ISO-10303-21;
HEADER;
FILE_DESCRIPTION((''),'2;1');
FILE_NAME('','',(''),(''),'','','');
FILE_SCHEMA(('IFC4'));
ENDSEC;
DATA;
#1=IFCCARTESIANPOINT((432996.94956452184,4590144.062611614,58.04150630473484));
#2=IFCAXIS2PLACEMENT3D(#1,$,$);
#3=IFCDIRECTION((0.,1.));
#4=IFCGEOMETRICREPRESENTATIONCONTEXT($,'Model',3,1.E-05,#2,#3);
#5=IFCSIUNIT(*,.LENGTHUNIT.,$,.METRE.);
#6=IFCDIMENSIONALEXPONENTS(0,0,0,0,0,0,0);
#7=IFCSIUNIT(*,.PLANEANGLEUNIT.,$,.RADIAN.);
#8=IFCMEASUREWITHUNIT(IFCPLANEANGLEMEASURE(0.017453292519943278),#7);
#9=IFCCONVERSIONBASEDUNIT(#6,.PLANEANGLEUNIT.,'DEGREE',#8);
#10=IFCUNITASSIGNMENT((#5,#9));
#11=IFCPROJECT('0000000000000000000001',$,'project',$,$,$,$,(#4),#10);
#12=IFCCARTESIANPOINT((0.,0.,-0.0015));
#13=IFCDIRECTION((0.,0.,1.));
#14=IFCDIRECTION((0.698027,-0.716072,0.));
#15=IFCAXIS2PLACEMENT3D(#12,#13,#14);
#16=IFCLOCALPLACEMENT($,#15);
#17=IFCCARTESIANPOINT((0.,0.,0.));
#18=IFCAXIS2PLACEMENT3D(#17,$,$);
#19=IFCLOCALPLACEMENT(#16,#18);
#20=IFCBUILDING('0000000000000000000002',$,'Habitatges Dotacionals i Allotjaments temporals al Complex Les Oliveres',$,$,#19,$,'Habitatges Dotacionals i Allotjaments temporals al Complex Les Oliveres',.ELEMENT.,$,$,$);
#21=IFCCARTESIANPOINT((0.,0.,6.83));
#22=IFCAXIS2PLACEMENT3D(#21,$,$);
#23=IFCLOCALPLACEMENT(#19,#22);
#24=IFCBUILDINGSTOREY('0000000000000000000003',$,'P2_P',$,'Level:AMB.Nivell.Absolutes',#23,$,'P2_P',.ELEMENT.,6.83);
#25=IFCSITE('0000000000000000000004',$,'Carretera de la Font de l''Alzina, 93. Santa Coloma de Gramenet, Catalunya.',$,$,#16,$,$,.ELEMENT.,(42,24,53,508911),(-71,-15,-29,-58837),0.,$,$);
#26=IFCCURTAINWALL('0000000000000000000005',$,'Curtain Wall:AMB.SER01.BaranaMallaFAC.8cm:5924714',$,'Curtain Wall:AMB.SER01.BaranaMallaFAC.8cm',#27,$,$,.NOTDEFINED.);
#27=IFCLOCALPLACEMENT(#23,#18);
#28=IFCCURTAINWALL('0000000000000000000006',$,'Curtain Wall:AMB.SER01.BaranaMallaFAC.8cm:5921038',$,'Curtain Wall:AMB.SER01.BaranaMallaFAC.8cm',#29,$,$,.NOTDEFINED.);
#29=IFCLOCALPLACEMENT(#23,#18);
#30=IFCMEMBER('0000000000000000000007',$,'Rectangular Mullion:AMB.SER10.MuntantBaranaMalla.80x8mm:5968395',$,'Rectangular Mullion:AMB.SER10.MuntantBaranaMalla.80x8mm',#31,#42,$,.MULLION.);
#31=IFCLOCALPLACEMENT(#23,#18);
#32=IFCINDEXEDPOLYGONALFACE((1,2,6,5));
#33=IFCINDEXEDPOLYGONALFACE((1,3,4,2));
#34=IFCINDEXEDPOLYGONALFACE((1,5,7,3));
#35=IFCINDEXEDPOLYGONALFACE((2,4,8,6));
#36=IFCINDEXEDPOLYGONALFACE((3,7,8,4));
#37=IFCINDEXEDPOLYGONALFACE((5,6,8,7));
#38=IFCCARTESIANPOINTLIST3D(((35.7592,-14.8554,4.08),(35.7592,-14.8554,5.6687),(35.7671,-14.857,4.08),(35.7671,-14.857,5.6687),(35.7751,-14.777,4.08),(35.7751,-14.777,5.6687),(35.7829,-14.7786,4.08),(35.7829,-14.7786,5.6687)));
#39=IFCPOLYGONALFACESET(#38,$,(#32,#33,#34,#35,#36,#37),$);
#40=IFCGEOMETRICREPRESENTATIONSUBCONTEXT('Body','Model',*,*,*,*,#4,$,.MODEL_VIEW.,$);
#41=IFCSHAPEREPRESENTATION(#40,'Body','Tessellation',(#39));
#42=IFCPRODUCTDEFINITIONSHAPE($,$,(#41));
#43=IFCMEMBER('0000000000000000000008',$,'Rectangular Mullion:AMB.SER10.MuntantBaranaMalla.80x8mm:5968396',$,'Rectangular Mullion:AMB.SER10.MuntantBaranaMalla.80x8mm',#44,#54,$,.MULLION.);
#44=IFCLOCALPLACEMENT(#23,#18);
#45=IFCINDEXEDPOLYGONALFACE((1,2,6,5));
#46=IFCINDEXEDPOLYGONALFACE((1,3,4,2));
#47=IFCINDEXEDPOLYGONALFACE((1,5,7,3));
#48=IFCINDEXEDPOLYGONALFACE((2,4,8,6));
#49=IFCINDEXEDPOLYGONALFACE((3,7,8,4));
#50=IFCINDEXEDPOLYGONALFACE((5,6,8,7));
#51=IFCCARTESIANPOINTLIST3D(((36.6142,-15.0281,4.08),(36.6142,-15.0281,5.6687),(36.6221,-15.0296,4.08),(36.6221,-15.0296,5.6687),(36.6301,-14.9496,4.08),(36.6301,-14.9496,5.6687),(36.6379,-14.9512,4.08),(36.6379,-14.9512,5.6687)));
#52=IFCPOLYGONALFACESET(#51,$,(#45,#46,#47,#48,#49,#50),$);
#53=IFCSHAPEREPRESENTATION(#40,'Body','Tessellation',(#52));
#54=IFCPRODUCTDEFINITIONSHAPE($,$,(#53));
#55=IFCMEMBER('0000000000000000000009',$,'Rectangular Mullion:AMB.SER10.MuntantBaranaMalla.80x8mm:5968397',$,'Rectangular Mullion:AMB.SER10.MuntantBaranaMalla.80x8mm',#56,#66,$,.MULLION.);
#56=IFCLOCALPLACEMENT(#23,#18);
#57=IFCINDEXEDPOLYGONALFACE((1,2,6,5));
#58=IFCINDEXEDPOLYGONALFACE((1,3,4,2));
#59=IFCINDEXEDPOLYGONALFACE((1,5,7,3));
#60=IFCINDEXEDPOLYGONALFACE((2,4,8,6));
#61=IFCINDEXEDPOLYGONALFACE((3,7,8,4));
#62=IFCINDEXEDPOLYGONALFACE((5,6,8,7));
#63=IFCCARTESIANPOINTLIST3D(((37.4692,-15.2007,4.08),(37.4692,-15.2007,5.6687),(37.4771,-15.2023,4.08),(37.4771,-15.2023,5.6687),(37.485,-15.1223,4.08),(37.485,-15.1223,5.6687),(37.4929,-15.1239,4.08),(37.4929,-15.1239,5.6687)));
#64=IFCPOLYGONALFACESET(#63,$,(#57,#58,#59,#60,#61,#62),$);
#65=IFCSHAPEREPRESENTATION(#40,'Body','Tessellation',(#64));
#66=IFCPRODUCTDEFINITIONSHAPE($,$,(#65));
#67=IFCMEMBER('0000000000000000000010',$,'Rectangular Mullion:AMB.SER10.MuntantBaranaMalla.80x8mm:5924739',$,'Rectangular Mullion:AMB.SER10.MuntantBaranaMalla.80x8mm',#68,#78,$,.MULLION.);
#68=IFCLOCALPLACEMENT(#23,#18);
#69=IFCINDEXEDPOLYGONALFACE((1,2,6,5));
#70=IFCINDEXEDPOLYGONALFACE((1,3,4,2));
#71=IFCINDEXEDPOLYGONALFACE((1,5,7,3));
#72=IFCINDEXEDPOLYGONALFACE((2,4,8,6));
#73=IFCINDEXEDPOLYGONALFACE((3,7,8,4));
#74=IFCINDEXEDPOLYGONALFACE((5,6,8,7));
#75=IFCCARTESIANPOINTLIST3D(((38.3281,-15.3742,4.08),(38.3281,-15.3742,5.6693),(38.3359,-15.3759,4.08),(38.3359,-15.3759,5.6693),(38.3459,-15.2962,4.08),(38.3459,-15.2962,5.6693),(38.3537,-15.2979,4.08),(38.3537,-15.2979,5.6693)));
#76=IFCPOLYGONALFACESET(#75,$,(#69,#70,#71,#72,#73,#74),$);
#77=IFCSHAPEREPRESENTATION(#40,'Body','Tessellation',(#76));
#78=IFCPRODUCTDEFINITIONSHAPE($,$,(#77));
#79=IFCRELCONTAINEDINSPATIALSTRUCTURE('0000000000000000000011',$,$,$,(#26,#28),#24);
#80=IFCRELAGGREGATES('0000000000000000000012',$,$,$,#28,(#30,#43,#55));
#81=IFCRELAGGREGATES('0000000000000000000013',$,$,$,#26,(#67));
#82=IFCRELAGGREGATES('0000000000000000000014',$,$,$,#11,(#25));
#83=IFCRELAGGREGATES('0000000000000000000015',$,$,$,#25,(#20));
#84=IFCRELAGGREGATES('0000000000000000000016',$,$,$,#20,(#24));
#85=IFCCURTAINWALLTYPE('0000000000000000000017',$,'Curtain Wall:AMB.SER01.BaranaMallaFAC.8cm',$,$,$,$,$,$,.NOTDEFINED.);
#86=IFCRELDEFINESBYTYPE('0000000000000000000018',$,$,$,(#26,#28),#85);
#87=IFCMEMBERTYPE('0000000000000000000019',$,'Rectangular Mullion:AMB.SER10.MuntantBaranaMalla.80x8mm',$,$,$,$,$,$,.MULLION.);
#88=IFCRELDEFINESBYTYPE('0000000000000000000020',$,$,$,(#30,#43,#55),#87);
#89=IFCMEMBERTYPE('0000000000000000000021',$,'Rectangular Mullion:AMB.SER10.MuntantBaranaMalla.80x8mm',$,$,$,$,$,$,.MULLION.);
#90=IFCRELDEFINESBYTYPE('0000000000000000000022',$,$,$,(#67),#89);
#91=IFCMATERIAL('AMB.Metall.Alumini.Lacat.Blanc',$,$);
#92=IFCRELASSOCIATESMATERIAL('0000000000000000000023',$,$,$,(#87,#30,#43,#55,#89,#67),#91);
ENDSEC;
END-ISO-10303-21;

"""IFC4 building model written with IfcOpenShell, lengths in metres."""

from ifc_helpers import new_model, entity, si_unit, converted_unit, direction, frame, origin, place, context, subcontext, project, spatial, indexed_curve, outline, extrude, source, transform, mapped, material, type_object, type_shapes, element, aggregate, save


model = new_model("IFC4")

# Units and contexts
model_context = context("Model", 3, precision=1e-05, world=frame((432996.94956452184, 4590144.062611614, 58.04150630473484)), true_north=direction((0.0, 1.0)))
body_context = subcontext(model_context, "Body", "Model", "MODEL_VIEW")
ifc_project = project(units=[si_unit("LENGTHUNIT", "METRE"), converted_unit("PLANEANGLEUNIT", "DEGREE", entity("IfcPlaneAngleMeasure", 0.017453292519943278), si_unit("PLANEANGLEUNIT", "RADIAN"), dimensions=[0, 0, 0, 0, 0, 0, 0])], contexts=[model_context])

# Site, building, storey
site_placement = place(None, frame((0.0, 0.0, -0.0015), z_axis=(0.0, 0.0, 1.0), x_axis=(0.698027, -0.716072, 0.0)))
site = spatial("IfcSite", under=ifc_project, at=site_placement, Name="Carretera de la Font de l'Alzina, 93. Santa Coloma de Gramenet, Catalunya.", CompositionType="ELEMENT", RefLatitude=(42, 24, 53, 508911), RefLongitude=(-71, -15, -29, -58837), RefElevation=0.0)
building_placement = place(site_placement, origin())
building = spatial("IfcBuilding", under=site, at=building_placement, Name="Habitatges Dotacionals i Allotjaments temporals al Complex Les Oliveres", LongName="Habitatges Dotacionals i Allotjaments temporals al Complex Les Oliveres", CompositionType="ELEMENT")
storey_placement = place(building_placement, frame((0.0, 0.0, 6.83)))
storey = spatial("IfcBuildingStorey", under=building, at=storey_placement, Name="P2_P", ObjectType="Level:AMB.Nivell.Absolutes", LongName="P2_P", CompositionType="ELEMENT", Elevation=6.83)

# Curtain wall
curtain_wall_type = type_object("IfcCurtainWallType", Name="Curtain Wall:AMB.SER01.BaranaMallaFAC.8cm", PredefinedType="NOTDEFINED")
curtain_wall_1_placement = place(storey_placement, frame((0.0, 0.0, -6.83)))
curtain_wall_1 = element("IfcCurtainWall", 1, at=curtain_wall_1_placement, inside=storey, type_object=curtain_wall_type, Name="Curtain Wall:AMB.SER01.BaranaMallaFAC.8cm:5924714", ObjectType="Curtain Wall:AMB.SER01.BaranaMallaFAC.8cm", PredefinedType="NOTDEFINED")
ifc_material_1 = material(Name="AMB.Metall.Alumini.Lacat.Blanc")

# Curtain wall, members
curtain_wall_2_placement = place(storey_placement, frame((0.0, 0.0, -6.83)))
curtain_wall_2 = element("IfcCurtainWall", 2, at=curtain_wall_2_placement, inside=storey, type_object=curtain_wall_type, Name="Curtain Wall:AMB.SER01.BaranaMallaFAC.8cm:5921038", ObjectType="Curtain Wall:AMB.SER01.BaranaMallaFAC.8cm", PredefinedType="NOTDEFINED")
member_type_1 = type_object("IfcMemberType", Name="Rectangular Mullion:AMB.SER10.MuntantBaranaMalla.80x8mm", PredefinedType="MULLION", material=ifc_material_1)
shared_shape_1 = source(origin(), body_context, "Body", "SweptSolid", [
    extrude(outline(indexed_curve([(-0.004, -0.04), (0.004, -0.04), (0.004, 0.04), (-0.004, 0.04), (-0.004, -0.04)], self_intersect=False)), frame((0.0, -0.04, -1.5887), z_axis=(0.0, 0.0, 1.0), x_axis=(-1.0, 0.0, 0.0)), (0.0, 0.0, 1.0), 1.5887),
])
type_shapes(member_type_1, [shared_shape_1])
member_1_placement = place(curtain_wall_2_placement, frame((35.7632, -14.8562, 10.91), z_axis=(0.0, 0.0, -1.0), x_axis=(0.980214, -0.197941, 0.0)))
member_1 = element("IfcMember", 3, at=member_1_placement, type_object=member_type_1, material=ifc_material_1, Name="Rectangular Mullion:AMB.SER10.MuntantBaranaMalla.80x8mm:5968395", ObjectType="Rectangular Mullion:AMB.SER10.MuntantBaranaMalla.80x8mm", PredefinedType="MULLION", context=body_context, shape_type="MappedRepresentation", body=[
    mapped(shared_shape_1, transform((0.0, 0.0, 0.0), scale=1.0)),
])
member_2_placement = place(curtain_wall_2_placement, frame((36.6181, -15.0289, 10.91), z_axis=(0.0, 0.0, -1.0), x_axis=(0.980214, -0.197941, 0.0)))
member_2 = element("IfcMember", 4, at=member_2_placement, type_object=member_type_1, material=ifc_material_1, Name="Rectangular Mullion:AMB.SER10.MuntantBaranaMalla.80x8mm:5968396", ObjectType="Rectangular Mullion:AMB.SER10.MuntantBaranaMalla.80x8mm", PredefinedType="MULLION", context=body_context, shape_type="MappedRepresentation", body=[
    mapped(shared_shape_1, transform((0.0, 0.0, 0.0), scale=1.0)),
])
member_3_placement = place(curtain_wall_2_placement, frame((37.4731, -15.2015, 10.91), z_axis=(0.0, 0.0, -1.0), x_axis=(0.980214, -0.197941, 0.0)))
member_3 = element("IfcMember", 5, at=member_3_placement, type_object=member_type_1, material=ifc_material_1, Name="Rectangular Mullion:AMB.SER10.MuntantBaranaMalla.80x8mm:5968397", ObjectType="Rectangular Mullion:AMB.SER10.MuntantBaranaMalla.80x8mm", PredefinedType="MULLION", context=body_context, shape_type="MappedRepresentation", body=[
    mapped(shared_shape_1, transform((0.0, 0.0, 0.0), scale=1.0)),
])

# Member
member_type_2 = type_object("IfcMemberType", Name="Rectangular Mullion:AMB.SER10.MuntantBaranaMalla.80x8mm", PredefinedType="MULLION", material=ifc_material_1)
shared_shape_2 = source(origin(), body_context, "Body", "SweptSolid", [
    extrude(outline(indexed_curve([(-0.004, -0.04), (0.004, -0.04), (0.004, 0.04), (-0.004, 0.04), (-0.004, -0.04)], self_intersect=False)), frame((-0.004, -0.04, -1.5893), z_axis=(0.0, 0.0, 1.0), x_axis=(-1.0, 0.0, 0.0)), (0.0, 0.0, 1.0), 1.5893),
])
type_shapes(member_type_2, [shared_shape_2])
member_4_placement = place(curtain_wall_1_placement, frame((38.3281, -15.3742, 12.4993), z_axis=(0.0, 0.0, 1.0), x_axis=(-0.975001, 0.2222, 0.0)))
member_4 = element("IfcMember", 6, at=member_4_placement, type_object=member_type_2, material=ifc_material_1, Name="Rectangular Mullion:AMB.SER10.MuntantBaranaMalla.80x8mm:5924739", ObjectType="Rectangular Mullion:AMB.SER10.MuntantBaranaMalla.80x8mm", PredefinedType="MULLION", context=body_context, shape_type="MappedRepresentation", body=[
    mapped(shared_shape_2, transform((0.0, 0.0, 0.0), scale=1.0)),
])

aggregate(curtain_wall_2, [member_1, member_2, member_3])
aggregate(curtain_wall_1, [member_4])

save(model, "model.ifc")
